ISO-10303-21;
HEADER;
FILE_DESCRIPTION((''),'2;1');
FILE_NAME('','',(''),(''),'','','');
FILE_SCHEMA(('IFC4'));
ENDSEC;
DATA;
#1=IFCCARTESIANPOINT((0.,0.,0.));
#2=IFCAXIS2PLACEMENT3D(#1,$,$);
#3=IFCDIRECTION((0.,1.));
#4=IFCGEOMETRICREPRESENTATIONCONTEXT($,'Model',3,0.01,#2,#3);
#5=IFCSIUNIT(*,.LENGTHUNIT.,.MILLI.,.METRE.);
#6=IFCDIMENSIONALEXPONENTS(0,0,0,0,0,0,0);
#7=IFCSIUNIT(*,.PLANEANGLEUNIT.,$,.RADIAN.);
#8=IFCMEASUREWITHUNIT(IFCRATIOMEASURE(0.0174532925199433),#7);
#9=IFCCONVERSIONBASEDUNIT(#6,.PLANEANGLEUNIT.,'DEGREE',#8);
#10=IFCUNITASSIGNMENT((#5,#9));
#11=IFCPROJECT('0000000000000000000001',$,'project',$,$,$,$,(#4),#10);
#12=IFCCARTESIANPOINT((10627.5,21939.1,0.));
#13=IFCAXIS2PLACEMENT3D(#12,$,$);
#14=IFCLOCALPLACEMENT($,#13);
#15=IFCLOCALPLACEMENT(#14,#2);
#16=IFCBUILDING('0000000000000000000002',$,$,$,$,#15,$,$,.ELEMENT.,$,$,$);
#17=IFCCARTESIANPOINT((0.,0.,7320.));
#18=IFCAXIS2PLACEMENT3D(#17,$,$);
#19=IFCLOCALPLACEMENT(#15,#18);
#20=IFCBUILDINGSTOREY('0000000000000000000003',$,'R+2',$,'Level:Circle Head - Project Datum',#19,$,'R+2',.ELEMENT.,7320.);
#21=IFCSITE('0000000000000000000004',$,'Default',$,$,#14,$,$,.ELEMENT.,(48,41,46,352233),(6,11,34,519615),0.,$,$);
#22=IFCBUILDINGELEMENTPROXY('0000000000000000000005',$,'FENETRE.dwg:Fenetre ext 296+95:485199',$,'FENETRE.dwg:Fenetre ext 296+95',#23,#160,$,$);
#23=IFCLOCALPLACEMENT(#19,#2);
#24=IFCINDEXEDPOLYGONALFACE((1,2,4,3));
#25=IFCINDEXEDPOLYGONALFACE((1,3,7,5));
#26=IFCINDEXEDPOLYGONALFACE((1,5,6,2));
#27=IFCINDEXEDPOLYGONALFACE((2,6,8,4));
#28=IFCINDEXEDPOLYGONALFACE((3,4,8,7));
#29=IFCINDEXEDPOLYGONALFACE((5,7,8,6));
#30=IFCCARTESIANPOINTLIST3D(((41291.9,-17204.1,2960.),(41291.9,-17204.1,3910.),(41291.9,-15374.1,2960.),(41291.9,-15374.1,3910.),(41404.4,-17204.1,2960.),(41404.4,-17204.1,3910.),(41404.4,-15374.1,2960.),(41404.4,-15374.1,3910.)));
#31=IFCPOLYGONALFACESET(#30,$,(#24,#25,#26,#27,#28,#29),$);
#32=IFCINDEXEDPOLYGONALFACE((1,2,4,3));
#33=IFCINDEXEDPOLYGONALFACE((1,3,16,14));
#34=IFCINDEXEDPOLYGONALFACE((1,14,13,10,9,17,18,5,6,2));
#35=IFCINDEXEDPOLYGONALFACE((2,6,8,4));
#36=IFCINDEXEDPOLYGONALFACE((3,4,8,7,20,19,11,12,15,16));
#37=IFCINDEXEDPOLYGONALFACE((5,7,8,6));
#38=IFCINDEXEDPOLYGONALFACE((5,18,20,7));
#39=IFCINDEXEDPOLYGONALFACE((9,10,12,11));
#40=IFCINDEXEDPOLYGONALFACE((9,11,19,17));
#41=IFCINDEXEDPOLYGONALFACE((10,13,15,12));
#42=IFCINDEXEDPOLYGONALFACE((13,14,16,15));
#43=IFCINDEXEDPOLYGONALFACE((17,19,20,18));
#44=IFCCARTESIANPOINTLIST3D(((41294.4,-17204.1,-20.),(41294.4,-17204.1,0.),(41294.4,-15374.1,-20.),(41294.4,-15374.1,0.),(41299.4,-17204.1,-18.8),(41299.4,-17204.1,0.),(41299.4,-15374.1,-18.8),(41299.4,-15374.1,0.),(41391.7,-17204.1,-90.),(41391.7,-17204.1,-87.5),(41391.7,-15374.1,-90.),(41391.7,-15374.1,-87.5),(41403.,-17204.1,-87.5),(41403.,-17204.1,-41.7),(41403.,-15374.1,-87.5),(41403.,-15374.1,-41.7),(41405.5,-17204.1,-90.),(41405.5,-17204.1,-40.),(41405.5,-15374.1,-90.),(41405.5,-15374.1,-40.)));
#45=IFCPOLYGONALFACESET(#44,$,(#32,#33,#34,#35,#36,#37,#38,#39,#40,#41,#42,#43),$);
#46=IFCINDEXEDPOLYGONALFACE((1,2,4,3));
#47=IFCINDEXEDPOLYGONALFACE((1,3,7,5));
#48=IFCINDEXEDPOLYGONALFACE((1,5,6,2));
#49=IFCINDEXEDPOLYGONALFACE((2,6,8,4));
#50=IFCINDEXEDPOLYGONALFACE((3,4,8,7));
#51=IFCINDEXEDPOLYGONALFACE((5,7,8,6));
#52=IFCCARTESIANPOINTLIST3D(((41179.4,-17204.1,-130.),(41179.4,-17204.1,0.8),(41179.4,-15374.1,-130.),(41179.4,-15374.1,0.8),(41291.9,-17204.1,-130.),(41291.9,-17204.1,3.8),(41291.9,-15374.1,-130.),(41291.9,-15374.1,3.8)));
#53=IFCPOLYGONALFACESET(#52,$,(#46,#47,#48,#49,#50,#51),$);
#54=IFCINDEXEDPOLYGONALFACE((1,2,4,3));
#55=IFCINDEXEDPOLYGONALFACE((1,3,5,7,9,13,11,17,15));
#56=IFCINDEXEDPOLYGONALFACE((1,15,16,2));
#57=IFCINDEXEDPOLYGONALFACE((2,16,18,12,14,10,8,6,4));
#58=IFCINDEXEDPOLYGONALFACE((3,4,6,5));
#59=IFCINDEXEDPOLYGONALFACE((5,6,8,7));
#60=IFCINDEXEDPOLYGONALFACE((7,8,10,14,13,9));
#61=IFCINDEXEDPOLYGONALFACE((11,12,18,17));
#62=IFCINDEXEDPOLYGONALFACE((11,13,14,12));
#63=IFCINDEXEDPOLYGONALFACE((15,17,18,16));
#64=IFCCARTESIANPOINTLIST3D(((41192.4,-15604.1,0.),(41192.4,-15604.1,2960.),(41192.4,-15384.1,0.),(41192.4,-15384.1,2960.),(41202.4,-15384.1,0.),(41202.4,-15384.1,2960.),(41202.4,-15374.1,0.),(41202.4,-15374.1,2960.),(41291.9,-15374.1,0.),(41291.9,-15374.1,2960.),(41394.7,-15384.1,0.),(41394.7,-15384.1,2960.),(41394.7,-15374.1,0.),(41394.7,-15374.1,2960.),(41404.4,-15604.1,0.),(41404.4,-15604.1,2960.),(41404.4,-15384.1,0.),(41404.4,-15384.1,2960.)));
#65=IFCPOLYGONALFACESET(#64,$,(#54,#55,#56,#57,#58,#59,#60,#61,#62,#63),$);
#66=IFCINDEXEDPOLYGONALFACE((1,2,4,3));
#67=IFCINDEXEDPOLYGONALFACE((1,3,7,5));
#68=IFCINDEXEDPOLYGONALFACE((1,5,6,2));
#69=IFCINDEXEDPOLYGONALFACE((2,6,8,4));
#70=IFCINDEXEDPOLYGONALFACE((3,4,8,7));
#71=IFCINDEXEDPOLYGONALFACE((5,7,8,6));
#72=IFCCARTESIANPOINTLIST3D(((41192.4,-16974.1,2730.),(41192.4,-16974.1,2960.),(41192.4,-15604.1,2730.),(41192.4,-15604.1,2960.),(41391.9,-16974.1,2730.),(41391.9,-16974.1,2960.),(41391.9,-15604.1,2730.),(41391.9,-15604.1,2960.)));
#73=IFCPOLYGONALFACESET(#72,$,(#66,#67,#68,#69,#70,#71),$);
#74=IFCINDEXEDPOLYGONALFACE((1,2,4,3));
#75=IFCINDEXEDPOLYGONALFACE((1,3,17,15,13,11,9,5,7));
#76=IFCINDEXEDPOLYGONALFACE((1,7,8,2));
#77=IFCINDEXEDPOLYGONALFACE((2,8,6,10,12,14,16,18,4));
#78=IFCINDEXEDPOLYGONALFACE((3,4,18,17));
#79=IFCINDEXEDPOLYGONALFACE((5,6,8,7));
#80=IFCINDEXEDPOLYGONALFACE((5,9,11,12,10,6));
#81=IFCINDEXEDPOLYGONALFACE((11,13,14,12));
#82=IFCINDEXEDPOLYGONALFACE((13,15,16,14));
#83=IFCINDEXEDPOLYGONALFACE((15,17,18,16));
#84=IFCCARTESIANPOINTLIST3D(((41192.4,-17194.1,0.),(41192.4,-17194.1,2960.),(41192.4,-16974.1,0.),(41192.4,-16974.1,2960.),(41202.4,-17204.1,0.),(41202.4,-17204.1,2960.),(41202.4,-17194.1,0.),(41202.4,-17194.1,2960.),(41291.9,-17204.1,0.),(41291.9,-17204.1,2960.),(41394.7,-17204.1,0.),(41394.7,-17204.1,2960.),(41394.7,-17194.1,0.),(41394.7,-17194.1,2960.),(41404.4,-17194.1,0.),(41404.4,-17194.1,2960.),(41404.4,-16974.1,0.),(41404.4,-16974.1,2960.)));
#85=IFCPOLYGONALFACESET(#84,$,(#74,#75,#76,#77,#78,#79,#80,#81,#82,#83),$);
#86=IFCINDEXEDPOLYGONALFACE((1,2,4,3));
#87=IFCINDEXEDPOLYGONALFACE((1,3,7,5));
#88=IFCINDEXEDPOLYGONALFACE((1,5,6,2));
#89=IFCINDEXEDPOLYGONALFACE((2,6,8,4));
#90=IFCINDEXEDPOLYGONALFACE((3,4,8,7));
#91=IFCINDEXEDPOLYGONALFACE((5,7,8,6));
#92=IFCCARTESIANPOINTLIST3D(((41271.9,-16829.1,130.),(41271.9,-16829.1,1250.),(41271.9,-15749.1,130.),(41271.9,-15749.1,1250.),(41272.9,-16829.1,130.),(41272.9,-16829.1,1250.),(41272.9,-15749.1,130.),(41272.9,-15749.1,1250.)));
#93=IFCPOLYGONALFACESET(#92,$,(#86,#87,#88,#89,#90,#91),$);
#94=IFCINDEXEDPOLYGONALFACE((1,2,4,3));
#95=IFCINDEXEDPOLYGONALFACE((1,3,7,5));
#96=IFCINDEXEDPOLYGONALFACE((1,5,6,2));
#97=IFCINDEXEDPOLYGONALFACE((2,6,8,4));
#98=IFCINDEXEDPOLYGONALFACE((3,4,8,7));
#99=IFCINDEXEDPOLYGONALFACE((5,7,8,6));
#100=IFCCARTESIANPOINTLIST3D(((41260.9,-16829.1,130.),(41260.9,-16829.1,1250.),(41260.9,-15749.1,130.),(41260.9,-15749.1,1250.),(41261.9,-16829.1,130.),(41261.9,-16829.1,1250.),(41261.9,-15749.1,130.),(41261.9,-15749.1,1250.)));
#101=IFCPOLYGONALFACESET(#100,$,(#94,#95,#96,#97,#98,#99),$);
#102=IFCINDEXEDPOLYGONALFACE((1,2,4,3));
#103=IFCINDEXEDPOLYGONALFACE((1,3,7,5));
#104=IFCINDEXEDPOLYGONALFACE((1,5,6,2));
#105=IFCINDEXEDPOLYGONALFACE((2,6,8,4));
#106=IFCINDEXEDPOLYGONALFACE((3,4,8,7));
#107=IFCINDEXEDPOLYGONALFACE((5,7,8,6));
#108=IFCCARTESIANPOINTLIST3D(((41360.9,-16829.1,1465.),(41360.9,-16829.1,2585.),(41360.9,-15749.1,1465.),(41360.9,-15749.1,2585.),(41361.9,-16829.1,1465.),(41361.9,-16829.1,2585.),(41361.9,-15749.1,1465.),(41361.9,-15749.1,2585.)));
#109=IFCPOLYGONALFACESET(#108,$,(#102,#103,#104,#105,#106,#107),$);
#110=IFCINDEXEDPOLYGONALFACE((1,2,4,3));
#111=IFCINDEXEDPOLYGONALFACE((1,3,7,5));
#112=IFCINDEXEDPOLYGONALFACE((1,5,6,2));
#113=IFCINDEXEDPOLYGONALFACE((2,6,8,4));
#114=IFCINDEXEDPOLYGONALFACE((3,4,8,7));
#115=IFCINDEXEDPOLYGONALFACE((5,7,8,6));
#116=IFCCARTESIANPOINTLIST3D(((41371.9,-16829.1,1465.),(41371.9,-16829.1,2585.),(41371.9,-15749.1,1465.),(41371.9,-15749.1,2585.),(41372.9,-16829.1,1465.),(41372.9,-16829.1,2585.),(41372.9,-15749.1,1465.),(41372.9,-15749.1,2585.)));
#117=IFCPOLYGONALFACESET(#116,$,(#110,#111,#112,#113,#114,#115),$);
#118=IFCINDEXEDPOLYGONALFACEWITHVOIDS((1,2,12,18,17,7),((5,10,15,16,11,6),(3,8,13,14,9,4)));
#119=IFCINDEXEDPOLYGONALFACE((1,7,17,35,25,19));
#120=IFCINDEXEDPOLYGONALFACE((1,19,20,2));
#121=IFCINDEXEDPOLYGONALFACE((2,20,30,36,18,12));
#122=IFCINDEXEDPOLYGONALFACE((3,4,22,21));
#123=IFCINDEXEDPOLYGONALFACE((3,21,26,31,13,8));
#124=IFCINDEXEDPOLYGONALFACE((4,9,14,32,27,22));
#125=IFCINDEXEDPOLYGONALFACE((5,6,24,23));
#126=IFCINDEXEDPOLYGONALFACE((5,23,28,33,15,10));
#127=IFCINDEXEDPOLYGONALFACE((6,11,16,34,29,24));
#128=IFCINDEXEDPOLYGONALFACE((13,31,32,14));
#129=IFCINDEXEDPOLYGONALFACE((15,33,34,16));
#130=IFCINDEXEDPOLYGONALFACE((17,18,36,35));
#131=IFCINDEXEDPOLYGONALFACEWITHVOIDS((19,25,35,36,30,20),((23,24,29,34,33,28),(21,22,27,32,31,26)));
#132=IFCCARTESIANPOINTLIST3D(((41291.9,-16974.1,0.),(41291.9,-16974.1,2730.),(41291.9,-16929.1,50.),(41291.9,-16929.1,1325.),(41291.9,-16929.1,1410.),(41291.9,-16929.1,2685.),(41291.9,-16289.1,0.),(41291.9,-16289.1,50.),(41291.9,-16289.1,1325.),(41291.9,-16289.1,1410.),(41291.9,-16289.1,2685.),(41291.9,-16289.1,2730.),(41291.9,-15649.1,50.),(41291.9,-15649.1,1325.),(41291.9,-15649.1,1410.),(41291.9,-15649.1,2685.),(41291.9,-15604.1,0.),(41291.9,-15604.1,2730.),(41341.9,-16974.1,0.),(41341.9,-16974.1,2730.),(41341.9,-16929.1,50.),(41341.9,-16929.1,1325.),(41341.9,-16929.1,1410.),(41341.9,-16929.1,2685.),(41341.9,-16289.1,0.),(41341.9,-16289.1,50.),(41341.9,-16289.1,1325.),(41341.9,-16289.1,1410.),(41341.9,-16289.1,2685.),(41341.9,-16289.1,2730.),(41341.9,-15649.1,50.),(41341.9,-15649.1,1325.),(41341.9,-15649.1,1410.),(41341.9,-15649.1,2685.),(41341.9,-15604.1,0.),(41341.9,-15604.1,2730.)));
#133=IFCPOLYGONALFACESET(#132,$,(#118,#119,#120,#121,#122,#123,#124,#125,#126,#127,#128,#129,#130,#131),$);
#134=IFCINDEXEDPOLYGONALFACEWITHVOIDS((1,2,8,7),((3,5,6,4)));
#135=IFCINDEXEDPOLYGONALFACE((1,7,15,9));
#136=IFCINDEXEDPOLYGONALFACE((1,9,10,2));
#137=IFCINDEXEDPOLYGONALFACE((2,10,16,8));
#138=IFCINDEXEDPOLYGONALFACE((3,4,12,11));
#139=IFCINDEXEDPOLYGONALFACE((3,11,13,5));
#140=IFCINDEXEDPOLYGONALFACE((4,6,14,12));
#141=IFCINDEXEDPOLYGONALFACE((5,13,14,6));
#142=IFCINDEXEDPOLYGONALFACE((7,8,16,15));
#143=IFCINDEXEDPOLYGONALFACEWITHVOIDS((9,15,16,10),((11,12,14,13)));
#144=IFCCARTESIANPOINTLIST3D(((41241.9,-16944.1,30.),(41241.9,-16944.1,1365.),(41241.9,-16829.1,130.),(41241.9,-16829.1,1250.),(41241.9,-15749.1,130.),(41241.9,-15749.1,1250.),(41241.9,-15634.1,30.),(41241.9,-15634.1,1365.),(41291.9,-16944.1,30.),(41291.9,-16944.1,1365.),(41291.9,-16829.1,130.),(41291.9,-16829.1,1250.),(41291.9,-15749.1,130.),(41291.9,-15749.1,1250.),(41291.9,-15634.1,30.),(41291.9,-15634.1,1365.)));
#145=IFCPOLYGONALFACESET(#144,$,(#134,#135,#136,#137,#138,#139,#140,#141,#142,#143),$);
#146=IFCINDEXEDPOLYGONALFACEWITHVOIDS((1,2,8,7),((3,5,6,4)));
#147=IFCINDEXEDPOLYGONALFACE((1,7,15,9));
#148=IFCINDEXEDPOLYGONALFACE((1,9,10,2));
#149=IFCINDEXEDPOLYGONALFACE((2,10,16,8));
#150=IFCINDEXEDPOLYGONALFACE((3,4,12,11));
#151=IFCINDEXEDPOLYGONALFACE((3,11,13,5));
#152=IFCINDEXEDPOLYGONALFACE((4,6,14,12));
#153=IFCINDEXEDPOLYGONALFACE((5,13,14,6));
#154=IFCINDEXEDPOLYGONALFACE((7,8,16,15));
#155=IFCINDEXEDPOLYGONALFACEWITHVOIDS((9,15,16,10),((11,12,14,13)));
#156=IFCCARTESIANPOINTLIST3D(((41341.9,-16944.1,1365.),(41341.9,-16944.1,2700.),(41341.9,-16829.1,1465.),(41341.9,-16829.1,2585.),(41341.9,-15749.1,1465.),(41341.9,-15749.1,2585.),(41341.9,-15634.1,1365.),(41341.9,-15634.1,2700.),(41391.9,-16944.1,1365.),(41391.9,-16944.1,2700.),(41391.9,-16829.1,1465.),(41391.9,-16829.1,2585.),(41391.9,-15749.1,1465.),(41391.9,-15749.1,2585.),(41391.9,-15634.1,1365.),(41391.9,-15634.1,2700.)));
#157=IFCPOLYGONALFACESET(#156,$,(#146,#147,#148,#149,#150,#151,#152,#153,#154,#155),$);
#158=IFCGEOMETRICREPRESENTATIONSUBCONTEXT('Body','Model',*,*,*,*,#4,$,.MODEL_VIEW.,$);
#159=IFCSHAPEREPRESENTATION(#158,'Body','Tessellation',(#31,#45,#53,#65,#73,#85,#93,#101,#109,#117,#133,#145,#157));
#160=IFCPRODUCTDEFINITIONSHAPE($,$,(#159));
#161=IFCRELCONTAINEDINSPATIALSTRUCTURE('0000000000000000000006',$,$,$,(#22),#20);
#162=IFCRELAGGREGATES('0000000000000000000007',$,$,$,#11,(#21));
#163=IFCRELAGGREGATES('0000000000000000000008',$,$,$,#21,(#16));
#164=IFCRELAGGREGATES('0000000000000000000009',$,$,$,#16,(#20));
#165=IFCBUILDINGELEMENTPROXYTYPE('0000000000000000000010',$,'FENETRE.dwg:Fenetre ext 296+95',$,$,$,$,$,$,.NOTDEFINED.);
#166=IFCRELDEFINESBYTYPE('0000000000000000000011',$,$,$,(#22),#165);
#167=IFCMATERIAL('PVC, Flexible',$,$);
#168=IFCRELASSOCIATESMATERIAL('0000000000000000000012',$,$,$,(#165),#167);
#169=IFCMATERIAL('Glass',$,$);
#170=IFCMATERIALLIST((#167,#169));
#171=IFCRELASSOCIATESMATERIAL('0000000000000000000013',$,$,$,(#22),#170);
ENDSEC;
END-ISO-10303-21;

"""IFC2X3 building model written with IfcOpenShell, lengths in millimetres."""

from ifc_helpers import new_model, entity, si_unit, converted_unit, direction, frame, frame_2d, origin, origin_2d_with_axis, place, context, subcontext, project, spatial, polyline, rectangle, outline, extrude, source, transform, mapped, material, material_list, type_object, type_shapes, element, save


model = new_model("IFC2X3")

# Units and contexts
model_context = context("Model", 3, precision=0.01, world=origin(), true_north=direction((0.0, 1.0)))
body_context = subcontext(model_context, "Body", "Model", "MODEL_VIEW")
ifc_project = project(units=[si_unit("LENGTHUNIT", "METRE", prefix="MILLI"), converted_unit("PLANEANGLEUNIT", "DEGREE", entity("IfcRatioMeasure", 0.0174532925199433), si_unit("PLANEANGLEUNIT", "RADIAN"), dimensions=[0, 0, 0, 0, 0, 0, 0])], contexts=[model_context])

# Site, building, storey
site_placement = place(None, frame((10627.5, 21939.1, 0.0)))
site = spatial("IfcSite", under=ifc_project, at=site_placement, Name="Default", CompositionType="ELEMENT", RefLatitude=(48, 41, 46, 352233), RefLongitude=(6, 11, 34, 519615), RefElevation=0.0)
building_placement = place(site_placement, origin())
building = spatial("IfcBuilding", under=site, at=building_placement, CompositionType="ELEMENT")
storey_placement = place(building_placement, frame((0.0, 0.0, 7320.0)))
storey = spatial("IfcBuildingStorey", under=building, at=storey_placement, Name="R+2", ObjectType="Level:Circle Head - Project Datum", LongName="R+2", CompositionType="ELEMENT", Elevation=7320.0)

# Building element proxy
ifc_material_1 = material(Name="PVC, Flexible")
ifc_material_2 = material(Name="Glass")
building_element_proxy_type_1 = type_object("IfcBuildingElementProxyType", Name="FENETRE.dwg:Fenetre ext 296+95", PredefinedType="NOTDEFINED", material=ifc_material_1)
shared_shape_1 = source(origin(), body_context, "Body", "SweptSolid", [
    extrude(rectangle(XDim=112.5, YDim=1830.0, at=origin_2d_with_axis()), frame((-10.4, -56.3, 2960.0), z_axis=(0.0, 0.0, 1.0), x_axis=(0.0, 1.0, 0.0)), (0.0, 0.0, 1.0), 950.0),
    extrude(outline(polyline([(27.5, -64.4), (47.5, -64.4), (47.5, -59.4), (28.8, -59.4), (7.5, 46.7), (-42.5, 46.7), (-42.5, 32.9), (-40.0, 32.9), (-40.0, 44.2), (5.8, 44.2), (27.5, -64.4)])), frame((-925.4, -66.9, -47.5), z_axis=(1.0, 0.0, 0.0), x_axis=(0.0, 0.0, 1.0)), (0.0, 0.0, 1.0), 1830.0),
    extrude(outline(polyline([(-54.5, -66.1), (58.0, -66.1), (54.5, 67.6), (-58.0, 64.6), (-54.5, -66.1)])), frame((-925.4, 56.3, -63.8), z_axis=(1.0, 0.0, 0.0), x_axis=(0.0, -0.999645, 0.02665)), (0.0, 0.0, 1.0), 1830.0),
    extrude(outline(polyline([(-97.0, -55.6), (5.9, -55.6), (95.4, -55.6), (95.4, -45.6), (105.4, -45.6), (105.4, 174.4), (-106.6, 174.4), (-106.6, -45.6), (-97.0, -45.6), (-97.0, -55.6)])), frame((849.0, -5.9, 0.0), z_axis=(0.0, 0.0, 1.0), x_axis=(0.0, 1.0, 0.0)), (0.0, 0.0, 1.0), 2960.0),
    extrude(rectangle(XDim=1370.0, YDim=199.5, at=origin_2d_with_axis()), frame((-10.4, -0.3, 2730.0), z_axis=(0.0, 0.0, 1.0), x_axis=(-1.0, 0.0, 0.0)), (0.0, 0.0, 1.0), 230.0),
    extrude(outline(polyline([(-55.6, 97.0), (-55.6, -5.9), (-55.6, -95.4), (-45.6, -95.4), (-45.6, -105.4), (174.4, -105.4), (174.4, 106.6), (-45.6, 106.6), (-45.6, 97.0), (-55.6, 97.0)])), frame((-869.9, -5.9, 0.0), z_axis=(0.0, 0.0, -1.0), x_axis=(1.0, 0.0, 0.0)), (0.0, 0.0, -1.0), 2960.0),
    extrude(rectangle(XDim=1080.0, YDim=1.0, at=origin_2d_with_axis()), frame((-10.4, 19.5, 130.0), z_axis=(0.0, 0.0, 1.0), x_axis=(-1.0, 0.0, 0.0)), (0.0, 0.0, 1.0), 1120.0),
    extrude(rectangle(XDim=1080.0, YDim=1.0, at=origin_2d_with_axis()), frame((-10.4, 30.5, 130.0), z_axis=(0.0, 0.0, 1.0), x_axis=(-1.0, 0.0, 0.0)), (0.0, 0.0, 1.0), 1120.0),
    extrude(rectangle(XDim=1080.0, YDim=1.0, at=frame_2d((0.0, 0.0), x_axis=(1.0, 0.0))), frame((-10.4, -69.5, 1465.0), z_axis=(0.0, 0.0, 1.0), x_axis=(-1.0, 0.0, 0.0)), (0.0, 0.0, 1.0), 1120.0),
    extrude(rectangle(XDim=1080.0, YDim=1.0, at=frame_2d((0.0, 0.0), x_axis=(1.0, 0.0))), frame((-10.4, -80.5, 1465.0), z_axis=(0.0, 0.0, 1.0), x_axis=(-1.0, 0.0, 0.0)), (0.0, 0.0, 1.0), 1120.0),
    extrude(outline(polyline([(-685.0, -1365.0), (0.0, -1365.0), (685.0, -1365.0), (685.0, 1365.0), (0.0, 1365.0), (-685.0, 1365.0), (-685.0, -1365.0)]), holes=[polyline([(-640.0, -1320.0), (-640.0, -45.0), (0.0, -45.0), (640.0, -45.0), (640.0, -1320.0), (0.0, -1320.0), (-640.0, -1320.0)]), polyline([(-640.0, 40.0), (-640.0, 1315.0), (0.0, 1315.0), (640.0, 1315.0), (640.0, 40.0), (0.0, 40.0), (-640.0, 40.0)])]), frame((-10.4, -50.0, 1365.0), z_axis=(0.0, 1.0, 0.0), x_axis=(1.0, 0.0, 0.0)), (0.0, 0.0, 1.0), 50.0),
    extrude(outline(polyline([(-655.0, -667.5), (655.0, -667.5), (655.0, 667.5), (-655.0, 667.5), (-655.0, -667.5)]), holes=[polyline([(-540.0, 552.5), (540.0, 552.5), (540.0, -567.5), (-540.0, -567.5), (-540.0, 552.5)])]), frame((-10.4, 0.0, 697.5), z_axis=(0.0, 1.0, 0.0), x_axis=(-1.0, 0.0, 0.0)), (0.0, 0.0, 1.0), 50.0),
    extrude(outline(polyline([(-655.0, -667.5), (655.0, -667.5), (655.0, 667.5), (-655.0, 667.5), (-655.0, -667.5)]), holes=[polyline([(-540.0, 552.5), (540.0, 552.5), (540.0, -567.5), (-540.0, -567.5), (-540.0, 552.5)])]), frame((-10.4, -100.0, 2032.5), z_axis=(0.0, 1.0, 0.0), x_axis=(-1.0, 0.0, 0.0)), (0.0, 0.0, 1.0), 50.0),
])
type_shapes(building_element_proxy_type_1, [shared_shape_1])
ifc_material_list_1 = material_list([ifc_material_1, ifc_material_2])
proxy_1_placement = place(storey_placement, frame((41291.9, -16278.7, 0.0), z_axis=(0.0, 0.0, 1.0), x_axis=(0.0, 1.0, 0.0)))
element("IfcBuildingElementProxy", 1, at=proxy_1_placement, inside=storey, type_object=building_element_proxy_type_1, material=ifc_material_list_1, Name="FENETRE.dwg:Fenetre ext 296+95:485199", ObjectType="FENETRE.dwg:Fenetre ext 296+95", context=body_context, shape_type="MappedRepresentation", body=[
    mapped(shared_shape_1, transform((0.0, 0.0, 0.0), scale=1.0)),
])

save(model, "model.ifc")
